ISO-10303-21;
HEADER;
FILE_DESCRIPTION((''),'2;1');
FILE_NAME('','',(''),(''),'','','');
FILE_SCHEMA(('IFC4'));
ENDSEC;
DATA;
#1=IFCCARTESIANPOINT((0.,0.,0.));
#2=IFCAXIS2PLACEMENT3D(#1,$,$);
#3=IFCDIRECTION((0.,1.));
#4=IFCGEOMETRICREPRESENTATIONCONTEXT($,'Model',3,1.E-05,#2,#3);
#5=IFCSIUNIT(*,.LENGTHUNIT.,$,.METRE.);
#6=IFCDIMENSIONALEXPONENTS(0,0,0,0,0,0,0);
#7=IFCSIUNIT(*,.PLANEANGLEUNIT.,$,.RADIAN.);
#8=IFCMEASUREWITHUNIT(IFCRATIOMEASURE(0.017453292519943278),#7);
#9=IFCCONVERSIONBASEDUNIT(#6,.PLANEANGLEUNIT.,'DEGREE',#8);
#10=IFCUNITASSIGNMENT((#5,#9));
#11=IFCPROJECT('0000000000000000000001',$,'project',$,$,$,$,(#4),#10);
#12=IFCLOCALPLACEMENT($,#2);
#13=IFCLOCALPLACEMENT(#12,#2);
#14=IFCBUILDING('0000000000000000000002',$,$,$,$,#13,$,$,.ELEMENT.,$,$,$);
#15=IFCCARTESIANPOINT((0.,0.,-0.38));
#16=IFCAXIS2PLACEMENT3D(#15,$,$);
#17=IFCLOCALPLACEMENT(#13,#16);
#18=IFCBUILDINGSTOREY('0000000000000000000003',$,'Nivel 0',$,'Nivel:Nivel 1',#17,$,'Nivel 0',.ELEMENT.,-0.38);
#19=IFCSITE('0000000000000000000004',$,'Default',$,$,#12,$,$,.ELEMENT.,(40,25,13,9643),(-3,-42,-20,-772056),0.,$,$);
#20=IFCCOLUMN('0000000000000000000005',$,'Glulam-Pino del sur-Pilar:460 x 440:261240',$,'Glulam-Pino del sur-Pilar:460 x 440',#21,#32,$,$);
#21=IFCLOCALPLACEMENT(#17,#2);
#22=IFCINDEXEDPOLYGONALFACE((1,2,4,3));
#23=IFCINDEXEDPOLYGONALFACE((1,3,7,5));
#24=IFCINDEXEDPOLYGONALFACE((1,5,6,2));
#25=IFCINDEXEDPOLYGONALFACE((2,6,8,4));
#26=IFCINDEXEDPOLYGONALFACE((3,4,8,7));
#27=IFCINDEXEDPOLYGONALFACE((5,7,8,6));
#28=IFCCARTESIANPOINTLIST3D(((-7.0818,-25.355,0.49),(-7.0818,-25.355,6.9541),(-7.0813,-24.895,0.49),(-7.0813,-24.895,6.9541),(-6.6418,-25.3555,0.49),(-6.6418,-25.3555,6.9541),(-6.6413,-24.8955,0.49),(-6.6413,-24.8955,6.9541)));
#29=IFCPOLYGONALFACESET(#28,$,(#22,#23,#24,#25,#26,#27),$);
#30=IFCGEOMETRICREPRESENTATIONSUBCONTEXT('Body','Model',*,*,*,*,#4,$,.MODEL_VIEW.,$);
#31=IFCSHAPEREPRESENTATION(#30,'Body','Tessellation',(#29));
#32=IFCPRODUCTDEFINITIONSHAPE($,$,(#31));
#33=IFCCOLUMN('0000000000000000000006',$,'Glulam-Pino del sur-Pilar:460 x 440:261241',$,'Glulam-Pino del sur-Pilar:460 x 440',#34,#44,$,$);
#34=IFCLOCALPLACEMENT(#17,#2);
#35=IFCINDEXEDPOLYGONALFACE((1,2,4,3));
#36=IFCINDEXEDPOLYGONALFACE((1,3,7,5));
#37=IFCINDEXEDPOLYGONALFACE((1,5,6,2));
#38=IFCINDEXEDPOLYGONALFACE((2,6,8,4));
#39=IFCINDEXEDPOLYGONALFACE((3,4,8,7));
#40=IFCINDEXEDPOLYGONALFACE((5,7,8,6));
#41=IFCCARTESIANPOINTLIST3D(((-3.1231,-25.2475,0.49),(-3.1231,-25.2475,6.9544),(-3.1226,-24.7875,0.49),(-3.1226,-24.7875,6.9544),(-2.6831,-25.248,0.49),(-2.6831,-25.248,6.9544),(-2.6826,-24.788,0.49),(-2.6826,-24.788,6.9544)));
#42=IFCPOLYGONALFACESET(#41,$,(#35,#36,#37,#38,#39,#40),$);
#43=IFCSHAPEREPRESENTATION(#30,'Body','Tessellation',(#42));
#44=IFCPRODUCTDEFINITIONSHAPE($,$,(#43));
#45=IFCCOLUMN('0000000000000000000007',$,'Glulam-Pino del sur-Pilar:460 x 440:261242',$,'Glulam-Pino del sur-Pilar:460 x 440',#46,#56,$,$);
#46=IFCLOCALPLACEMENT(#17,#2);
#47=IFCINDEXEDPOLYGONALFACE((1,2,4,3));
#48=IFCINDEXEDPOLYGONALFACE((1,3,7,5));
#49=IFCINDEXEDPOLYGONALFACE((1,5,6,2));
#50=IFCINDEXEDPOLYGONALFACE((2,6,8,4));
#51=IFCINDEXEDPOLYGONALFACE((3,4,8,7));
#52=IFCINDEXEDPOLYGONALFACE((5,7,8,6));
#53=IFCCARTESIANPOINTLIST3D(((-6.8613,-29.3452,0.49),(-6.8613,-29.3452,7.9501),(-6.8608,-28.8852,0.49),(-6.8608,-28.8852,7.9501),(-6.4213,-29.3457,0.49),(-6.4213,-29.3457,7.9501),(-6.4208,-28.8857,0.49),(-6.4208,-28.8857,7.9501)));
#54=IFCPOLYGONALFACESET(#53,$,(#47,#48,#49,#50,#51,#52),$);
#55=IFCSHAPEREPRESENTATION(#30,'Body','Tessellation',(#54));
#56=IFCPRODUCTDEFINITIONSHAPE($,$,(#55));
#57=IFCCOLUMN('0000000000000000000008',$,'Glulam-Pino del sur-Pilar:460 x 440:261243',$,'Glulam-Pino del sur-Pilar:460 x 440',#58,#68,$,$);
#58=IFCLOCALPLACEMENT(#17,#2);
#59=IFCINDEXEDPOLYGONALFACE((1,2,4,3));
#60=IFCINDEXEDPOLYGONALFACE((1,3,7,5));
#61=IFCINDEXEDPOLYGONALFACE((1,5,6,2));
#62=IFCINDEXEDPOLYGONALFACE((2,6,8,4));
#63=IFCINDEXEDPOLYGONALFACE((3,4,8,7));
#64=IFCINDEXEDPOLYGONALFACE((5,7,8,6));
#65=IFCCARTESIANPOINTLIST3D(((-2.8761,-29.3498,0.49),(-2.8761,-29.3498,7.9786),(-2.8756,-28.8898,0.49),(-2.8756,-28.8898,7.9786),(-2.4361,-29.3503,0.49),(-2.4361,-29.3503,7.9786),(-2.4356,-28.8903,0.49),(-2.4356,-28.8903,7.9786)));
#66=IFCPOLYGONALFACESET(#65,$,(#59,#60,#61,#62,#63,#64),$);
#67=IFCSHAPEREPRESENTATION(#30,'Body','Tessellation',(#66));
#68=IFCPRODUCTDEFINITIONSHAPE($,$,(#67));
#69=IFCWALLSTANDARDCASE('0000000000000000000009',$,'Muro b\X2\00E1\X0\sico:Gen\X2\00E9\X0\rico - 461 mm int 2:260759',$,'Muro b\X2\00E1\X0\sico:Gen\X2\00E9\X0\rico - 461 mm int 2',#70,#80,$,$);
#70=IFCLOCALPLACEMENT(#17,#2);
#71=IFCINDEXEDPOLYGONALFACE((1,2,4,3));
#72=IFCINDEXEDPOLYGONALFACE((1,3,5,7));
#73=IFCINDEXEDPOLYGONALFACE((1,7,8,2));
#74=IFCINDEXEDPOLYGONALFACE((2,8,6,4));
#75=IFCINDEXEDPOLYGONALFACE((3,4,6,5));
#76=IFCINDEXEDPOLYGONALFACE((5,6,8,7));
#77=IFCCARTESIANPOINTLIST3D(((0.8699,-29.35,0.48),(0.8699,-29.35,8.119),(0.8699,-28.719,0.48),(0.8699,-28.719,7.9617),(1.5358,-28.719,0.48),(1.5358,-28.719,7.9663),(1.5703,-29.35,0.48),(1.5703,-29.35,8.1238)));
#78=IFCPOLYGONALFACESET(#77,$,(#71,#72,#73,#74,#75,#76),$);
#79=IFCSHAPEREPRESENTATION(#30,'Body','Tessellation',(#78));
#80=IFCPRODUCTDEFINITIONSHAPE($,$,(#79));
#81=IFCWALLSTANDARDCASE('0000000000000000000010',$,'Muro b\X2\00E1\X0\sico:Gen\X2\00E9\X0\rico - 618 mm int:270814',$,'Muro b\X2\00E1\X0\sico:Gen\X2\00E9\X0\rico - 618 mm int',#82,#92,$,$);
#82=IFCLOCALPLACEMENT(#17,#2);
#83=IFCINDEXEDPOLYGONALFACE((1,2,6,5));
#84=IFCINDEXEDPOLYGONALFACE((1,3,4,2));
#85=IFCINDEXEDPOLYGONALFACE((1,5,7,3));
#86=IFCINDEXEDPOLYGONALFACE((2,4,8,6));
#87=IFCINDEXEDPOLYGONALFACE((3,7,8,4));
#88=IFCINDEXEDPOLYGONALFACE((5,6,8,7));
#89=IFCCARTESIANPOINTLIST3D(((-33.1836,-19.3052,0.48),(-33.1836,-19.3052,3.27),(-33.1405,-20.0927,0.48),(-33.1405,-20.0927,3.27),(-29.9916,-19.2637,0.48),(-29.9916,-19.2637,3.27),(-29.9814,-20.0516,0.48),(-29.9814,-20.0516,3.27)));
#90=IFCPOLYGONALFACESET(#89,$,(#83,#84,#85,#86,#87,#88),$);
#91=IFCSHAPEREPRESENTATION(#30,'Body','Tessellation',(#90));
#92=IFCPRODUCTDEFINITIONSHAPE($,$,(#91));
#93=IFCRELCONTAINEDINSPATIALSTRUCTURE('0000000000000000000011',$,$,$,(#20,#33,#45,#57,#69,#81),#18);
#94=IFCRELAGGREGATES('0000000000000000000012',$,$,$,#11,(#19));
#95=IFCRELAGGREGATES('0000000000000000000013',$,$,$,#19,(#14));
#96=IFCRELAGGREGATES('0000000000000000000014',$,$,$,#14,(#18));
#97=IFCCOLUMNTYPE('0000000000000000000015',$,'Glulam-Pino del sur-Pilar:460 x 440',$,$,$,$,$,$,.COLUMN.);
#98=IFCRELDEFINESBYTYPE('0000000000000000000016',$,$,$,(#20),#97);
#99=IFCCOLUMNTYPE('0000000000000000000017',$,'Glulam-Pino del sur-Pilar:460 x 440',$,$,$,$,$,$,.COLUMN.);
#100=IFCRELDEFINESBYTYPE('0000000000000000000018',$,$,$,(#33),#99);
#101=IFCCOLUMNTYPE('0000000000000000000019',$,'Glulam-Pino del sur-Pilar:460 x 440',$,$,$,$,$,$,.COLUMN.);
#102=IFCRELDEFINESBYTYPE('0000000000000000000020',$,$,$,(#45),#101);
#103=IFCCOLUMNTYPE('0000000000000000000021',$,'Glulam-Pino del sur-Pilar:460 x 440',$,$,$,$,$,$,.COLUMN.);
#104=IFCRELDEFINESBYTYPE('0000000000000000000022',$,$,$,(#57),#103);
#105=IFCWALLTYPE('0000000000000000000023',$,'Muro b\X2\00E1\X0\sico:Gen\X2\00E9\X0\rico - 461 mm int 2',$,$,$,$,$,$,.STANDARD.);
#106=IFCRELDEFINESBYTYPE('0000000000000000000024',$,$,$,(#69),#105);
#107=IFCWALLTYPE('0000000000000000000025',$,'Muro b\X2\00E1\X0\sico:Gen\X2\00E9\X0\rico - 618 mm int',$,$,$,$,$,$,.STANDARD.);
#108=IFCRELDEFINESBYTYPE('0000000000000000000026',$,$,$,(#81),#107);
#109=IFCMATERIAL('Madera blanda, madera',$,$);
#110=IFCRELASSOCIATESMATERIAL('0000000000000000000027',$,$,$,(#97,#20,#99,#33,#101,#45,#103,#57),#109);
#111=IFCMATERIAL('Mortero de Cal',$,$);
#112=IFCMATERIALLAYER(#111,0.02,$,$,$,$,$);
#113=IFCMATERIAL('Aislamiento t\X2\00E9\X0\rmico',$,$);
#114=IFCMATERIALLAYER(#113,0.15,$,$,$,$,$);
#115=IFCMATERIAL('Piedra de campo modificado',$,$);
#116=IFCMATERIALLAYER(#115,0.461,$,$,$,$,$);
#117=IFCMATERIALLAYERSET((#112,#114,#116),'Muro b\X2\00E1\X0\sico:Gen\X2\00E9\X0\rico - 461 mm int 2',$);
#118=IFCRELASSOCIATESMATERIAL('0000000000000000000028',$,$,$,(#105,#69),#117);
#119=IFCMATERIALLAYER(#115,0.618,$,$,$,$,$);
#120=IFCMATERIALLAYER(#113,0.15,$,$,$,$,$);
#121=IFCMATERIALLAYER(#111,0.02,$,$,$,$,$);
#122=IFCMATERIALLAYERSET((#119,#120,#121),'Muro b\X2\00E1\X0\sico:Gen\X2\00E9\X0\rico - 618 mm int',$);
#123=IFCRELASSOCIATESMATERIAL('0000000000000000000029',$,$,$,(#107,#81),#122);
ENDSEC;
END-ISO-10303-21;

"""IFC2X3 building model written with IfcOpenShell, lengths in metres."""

from ifc_helpers import new_model, entity, si_unit, converted_unit, direction, frame, origin, origin_2d_with_axis, place, context, subcontext, project, spatial, polyline, rectangle, outline, extrude, clip, bounded_halfspace, source, transform, mapped, material, layer, layer_set, layer_usage, type_object, type_shapes, element, save


model = new_model("IFC2X3")

# Units and contexts
model_context = context("Model", 3, precision=1e-05, world=origin(), true_north=direction((0.0, 1.0)))
body_context = subcontext(model_context, "Body", "Model", "MODEL_VIEW")
ifc_project = project(units=[si_unit("LENGTHUNIT", "METRE"), converted_unit("PLANEANGLEUNIT", "DEGREE", entity("IfcRatioMeasure", 0.017453292519943278), si_unit("PLANEANGLEUNIT", "RADIAN"), dimensions=[0, 0, 0, 0, 0, 0, 0])], contexts=[model_context])

# Site, building, storey
site_placement = place(None, origin())
site = spatial("IfcSite", under=ifc_project, at=site_placement, Name="Default", CompositionType="ELEMENT", RefLatitude=(40, 25, 13, 9643), RefLongitude=(-3, -42, -20, -772056), RefElevation=0.0)
building_placement = place(site_placement, origin())
building = spatial("IfcBuilding", under=site, at=building_placement, CompositionType="ELEMENT")
storey_placement = place(building_placement, frame((0.0, 0.0, -0.38)))
storey = spatial("IfcBuildingStorey", under=building, at=storey_placement, Name="Nivel 0", ObjectType="Nivel:Nivel 1", LongName="Nivel 0", CompositionType="ELEMENT", Elevation=-0.38)

# Columns
ifc_material_1 = material(Name="Madera blanda, madera")
column_type_1 = type_object("IfcColumnType", Name="Glulam-Pino del sur-Pilar:460 x 440", PredefinedType="COLUMN", material=ifc_material_1)
shared_shape_1 = source(origin(), body_context, "Body", "SweptSolid", [
    extrude(rectangle(XDim=0.46, YDim=0.44, at=origin_2d_with_axis()), frame((-6.8615, -25.1252, 0.11), z_axis=(0.0, 0.0, 1.0), x_axis=(0.001152, 0.999999, 0.0)), (0.0, 0.0, 1.0), 6.4641),
])
type_shapes(column_type_1, [shared_shape_1])
column_1_placement = place(storey_placement, frame((0.0, 0.0, 0.38)))
element("IfcColumn", 1, at=column_1_placement, inside=storey, type_object=column_type_1, material=ifc_material_1, Name="Glulam-Pino del sur-Pilar:460 x 440:261240", ObjectType="Glulam-Pino del sur-Pilar:460 x 440", context=body_context, shape_type="MappedRepresentation", body=[
    mapped(shared_shape_1, transform((0.0, 0.0, 0.0), scale=1.0)),
])
column_type_2 = type_object("IfcColumnType", Name="Glulam-Pino del sur-Pilar:460 x 440", PredefinedType="COLUMN", material=ifc_material_1)
shared_shape_2 = source(origin(), body_context, "Body", "SweptSolid", [
    extrude(rectangle(XDim=0.46, YDim=0.44, at=origin_2d_with_axis()), frame((-2.9029, -25.0177, 0.11), z_axis=(0.0, 0.0, 1.0), x_axis=(0.001152, 0.999999, 0.0)), (0.0, 0.0, 1.0), 6.4644),
])
type_shapes(column_type_2, [shared_shape_2])
column_2_placement = place(storey_placement, frame((0.0, 0.0, 0.38)))
element("IfcColumn", 2, at=column_2_placement, inside=storey, type_object=column_type_2, material=ifc_material_1, Name="Glulam-Pino del sur-Pilar:460 x 440:261241", ObjectType="Glulam-Pino del sur-Pilar:460 x 440", context=body_context, shape_type="MappedRepresentation", body=[
    mapped(shared_shape_2, transform((0.0, 0.0, 0.0), scale=1.0)),
])
column_type_3 = type_object("IfcColumnType", Name="Glulam-Pino del sur-Pilar:460 x 440", PredefinedType="COLUMN", material=ifc_material_1)
shared_shape_3 = source(origin(), body_context, "Body", "SweptSolid", [
    extrude(rectangle(XDim=0.46, YDim=0.44, at=origin_2d_with_axis()), frame((-6.6411, -29.1155, 0.11), z_axis=(0.0, 0.0, 1.0), x_axis=(0.001152, 0.999999, 0.0)), (0.0, 0.0, 1.0), 7.4601),
])
type_shapes(column_type_3, [shared_shape_3])
column_3_placement = place(storey_placement, frame((0.0, 0.0, 0.38)))
element("IfcColumn", 3, at=column_3_placement, inside=storey, type_object=column_type_3, material=ifc_material_1, Name="Glulam-Pino del sur-Pilar:460 x 440:261242", ObjectType="Glulam-Pino del sur-Pilar:460 x 440", context=body_context, shape_type="MappedRepresentation", body=[
    mapped(shared_shape_3, transform((0.0, 0.0, 0.0), scale=1.0)),
])
column_type_4 = type_object("IfcColumnType", Name="Glulam-Pino del sur-Pilar:460 x 440", PredefinedType="COLUMN", material=ifc_material_1)
shared_shape_4 = source(origin(), body_context, "Body", "SweptSolid", [
    extrude(rectangle(XDim=0.46, YDim=0.44, at=origin_2d_with_axis()), frame((-2.6558, -29.12, 0.11), z_axis=(0.0, 0.0, 1.0), x_axis=(0.001152, 0.999999, 0.0)), (0.0, 0.0, 1.0), 7.4886),
])
type_shapes(column_type_4, [shared_shape_4])
column_4_placement = place(storey_placement, frame((0.0, 0.0, 0.38)))
element("IfcColumn", 4, at=column_4_placement, inside=storey, type_object=column_type_4, material=ifc_material_1, Name="Glulam-Pino del sur-Pilar:460 x 440:261243", ObjectType="Glulam-Pino del sur-Pilar:460 x 440", context=body_context, shape_type="MappedRepresentation", body=[
    mapped(shared_shape_4, transform((0.0, 0.0, 0.0), scale=1.0)),
])

# Walls
ifc_material_2 = material(Name="Mortero de Cal")
ifc_layer_1 = layer(ifc_material_2, 0.02)
ifc_material_3 = material(Name="Aislamiento térmico")
ifc_layer_2 = layer(ifc_material_3, 0.15)
ifc_material_4 = material(Name="Piedra de campo modificado")
ifc_layer_3 = layer(ifc_material_4, 0.461)
ifc_layer_set_1 = layer_set([ifc_layer_1, ifc_layer_2, ifc_layer_3], Name="Muro básico:Genérico - 461 mm int 2")
ifc_layer_usage_1 = layer_usage(ifc_layer_set_1, "AXIS2", "NEGATIVE", 0.3155)
wall_type_1 = type_object("IfcWallType", Name="Muro básico:Genérico - 461 mm int 2", PredefinedType="STANDARD", material=ifc_layer_set_1)
wall_1_placement = place(storey_placement, frame((1.5703, -29.0345, 0.48), z_axis=(0.0, 0.0, 1.0), x_axis=(-1.0, 0.0, 0.0)))
element("IfcWallStandardCase", 5, at=wall_1_placement, inside=storey, type_object=wall_type_1, material=ifc_layer_usage_1, Name="Muro básico:Genérico - 461 mm int 2:260759", ObjectType="Muro básico:Genérico - 461 mm int 2", context=body_context, shape_type="Clipping", body=[
    clip(extrude(outline(polyline([(0.7004, -0.3155), (0.7004, 0.3155), (0.0, 0.3155), (0.0345, -0.3155), (0.6254, -0.3155), (0.7004, -0.3155)])), origin(), (0.0, 0.0, 1.0), 7.6438), bounded_halfspace(frame((0.0345, -0.3155, 7.4863), z_axis=(0.006656, -0.24183, 0.970296), x_axis=(0.999621, 0.027514, 0.0)), False, frame((0.0345, -0.3155, 7.4863)), polyline([(0.0, 0.0), (0.5909, 0.0), (0.6659, 0.0), (0.6659, 0.631), (-0.0345, 0.631), (0.0, 0.0)]))),
])
ifc_layer_4 = layer(ifc_material_4, 0.618)
ifc_layer_5 = layer(ifc_material_3, 0.15)
ifc_layer_6 = layer(ifc_material_2, 0.02)
ifc_layer_set_2 = layer_set([ifc_layer_4, ifc_layer_5, ifc_layer_6], Name="Muro básico:Genérico - 618 mm int")
ifc_layer_usage_2 = layer_usage(ifc_layer_set_2, "AXIS2", "NEGATIVE", 0.394)
wall_type_2 = type_object("IfcWallType", Name="Muro básico:Genérico - 618 mm int", PredefinedType="STANDARD", material=ifc_layer_set_2)
wall_2_placement = place(storey_placement, frame((-29.9865, -19.6577, 0.48), z_axis=(0.0, 0.0, 1.0), x_axis=(-0.999916, -0.01299, 0.0)))
element("IfcWallStandardCase", 6, at=wall_2_placement, inside=storey, type_object=wall_type_2, material=ifc_layer_usage_2, Name="Muro básico:Genérico - 618 mm int:270814", ObjectType="Muro básico:Genérico - 618 mm int", context=body_context, shape_type="SweptSolid", body=[
    extrude(outline(polyline([(3.1922, -0.394), (3.1594, 0.394), (0.0, 0.394), (0.0, -0.394), (3.1922, -0.394)])), origin(), (0.0, 0.0, 1.0), 2.79),
])

save(model, "model.ifc")
